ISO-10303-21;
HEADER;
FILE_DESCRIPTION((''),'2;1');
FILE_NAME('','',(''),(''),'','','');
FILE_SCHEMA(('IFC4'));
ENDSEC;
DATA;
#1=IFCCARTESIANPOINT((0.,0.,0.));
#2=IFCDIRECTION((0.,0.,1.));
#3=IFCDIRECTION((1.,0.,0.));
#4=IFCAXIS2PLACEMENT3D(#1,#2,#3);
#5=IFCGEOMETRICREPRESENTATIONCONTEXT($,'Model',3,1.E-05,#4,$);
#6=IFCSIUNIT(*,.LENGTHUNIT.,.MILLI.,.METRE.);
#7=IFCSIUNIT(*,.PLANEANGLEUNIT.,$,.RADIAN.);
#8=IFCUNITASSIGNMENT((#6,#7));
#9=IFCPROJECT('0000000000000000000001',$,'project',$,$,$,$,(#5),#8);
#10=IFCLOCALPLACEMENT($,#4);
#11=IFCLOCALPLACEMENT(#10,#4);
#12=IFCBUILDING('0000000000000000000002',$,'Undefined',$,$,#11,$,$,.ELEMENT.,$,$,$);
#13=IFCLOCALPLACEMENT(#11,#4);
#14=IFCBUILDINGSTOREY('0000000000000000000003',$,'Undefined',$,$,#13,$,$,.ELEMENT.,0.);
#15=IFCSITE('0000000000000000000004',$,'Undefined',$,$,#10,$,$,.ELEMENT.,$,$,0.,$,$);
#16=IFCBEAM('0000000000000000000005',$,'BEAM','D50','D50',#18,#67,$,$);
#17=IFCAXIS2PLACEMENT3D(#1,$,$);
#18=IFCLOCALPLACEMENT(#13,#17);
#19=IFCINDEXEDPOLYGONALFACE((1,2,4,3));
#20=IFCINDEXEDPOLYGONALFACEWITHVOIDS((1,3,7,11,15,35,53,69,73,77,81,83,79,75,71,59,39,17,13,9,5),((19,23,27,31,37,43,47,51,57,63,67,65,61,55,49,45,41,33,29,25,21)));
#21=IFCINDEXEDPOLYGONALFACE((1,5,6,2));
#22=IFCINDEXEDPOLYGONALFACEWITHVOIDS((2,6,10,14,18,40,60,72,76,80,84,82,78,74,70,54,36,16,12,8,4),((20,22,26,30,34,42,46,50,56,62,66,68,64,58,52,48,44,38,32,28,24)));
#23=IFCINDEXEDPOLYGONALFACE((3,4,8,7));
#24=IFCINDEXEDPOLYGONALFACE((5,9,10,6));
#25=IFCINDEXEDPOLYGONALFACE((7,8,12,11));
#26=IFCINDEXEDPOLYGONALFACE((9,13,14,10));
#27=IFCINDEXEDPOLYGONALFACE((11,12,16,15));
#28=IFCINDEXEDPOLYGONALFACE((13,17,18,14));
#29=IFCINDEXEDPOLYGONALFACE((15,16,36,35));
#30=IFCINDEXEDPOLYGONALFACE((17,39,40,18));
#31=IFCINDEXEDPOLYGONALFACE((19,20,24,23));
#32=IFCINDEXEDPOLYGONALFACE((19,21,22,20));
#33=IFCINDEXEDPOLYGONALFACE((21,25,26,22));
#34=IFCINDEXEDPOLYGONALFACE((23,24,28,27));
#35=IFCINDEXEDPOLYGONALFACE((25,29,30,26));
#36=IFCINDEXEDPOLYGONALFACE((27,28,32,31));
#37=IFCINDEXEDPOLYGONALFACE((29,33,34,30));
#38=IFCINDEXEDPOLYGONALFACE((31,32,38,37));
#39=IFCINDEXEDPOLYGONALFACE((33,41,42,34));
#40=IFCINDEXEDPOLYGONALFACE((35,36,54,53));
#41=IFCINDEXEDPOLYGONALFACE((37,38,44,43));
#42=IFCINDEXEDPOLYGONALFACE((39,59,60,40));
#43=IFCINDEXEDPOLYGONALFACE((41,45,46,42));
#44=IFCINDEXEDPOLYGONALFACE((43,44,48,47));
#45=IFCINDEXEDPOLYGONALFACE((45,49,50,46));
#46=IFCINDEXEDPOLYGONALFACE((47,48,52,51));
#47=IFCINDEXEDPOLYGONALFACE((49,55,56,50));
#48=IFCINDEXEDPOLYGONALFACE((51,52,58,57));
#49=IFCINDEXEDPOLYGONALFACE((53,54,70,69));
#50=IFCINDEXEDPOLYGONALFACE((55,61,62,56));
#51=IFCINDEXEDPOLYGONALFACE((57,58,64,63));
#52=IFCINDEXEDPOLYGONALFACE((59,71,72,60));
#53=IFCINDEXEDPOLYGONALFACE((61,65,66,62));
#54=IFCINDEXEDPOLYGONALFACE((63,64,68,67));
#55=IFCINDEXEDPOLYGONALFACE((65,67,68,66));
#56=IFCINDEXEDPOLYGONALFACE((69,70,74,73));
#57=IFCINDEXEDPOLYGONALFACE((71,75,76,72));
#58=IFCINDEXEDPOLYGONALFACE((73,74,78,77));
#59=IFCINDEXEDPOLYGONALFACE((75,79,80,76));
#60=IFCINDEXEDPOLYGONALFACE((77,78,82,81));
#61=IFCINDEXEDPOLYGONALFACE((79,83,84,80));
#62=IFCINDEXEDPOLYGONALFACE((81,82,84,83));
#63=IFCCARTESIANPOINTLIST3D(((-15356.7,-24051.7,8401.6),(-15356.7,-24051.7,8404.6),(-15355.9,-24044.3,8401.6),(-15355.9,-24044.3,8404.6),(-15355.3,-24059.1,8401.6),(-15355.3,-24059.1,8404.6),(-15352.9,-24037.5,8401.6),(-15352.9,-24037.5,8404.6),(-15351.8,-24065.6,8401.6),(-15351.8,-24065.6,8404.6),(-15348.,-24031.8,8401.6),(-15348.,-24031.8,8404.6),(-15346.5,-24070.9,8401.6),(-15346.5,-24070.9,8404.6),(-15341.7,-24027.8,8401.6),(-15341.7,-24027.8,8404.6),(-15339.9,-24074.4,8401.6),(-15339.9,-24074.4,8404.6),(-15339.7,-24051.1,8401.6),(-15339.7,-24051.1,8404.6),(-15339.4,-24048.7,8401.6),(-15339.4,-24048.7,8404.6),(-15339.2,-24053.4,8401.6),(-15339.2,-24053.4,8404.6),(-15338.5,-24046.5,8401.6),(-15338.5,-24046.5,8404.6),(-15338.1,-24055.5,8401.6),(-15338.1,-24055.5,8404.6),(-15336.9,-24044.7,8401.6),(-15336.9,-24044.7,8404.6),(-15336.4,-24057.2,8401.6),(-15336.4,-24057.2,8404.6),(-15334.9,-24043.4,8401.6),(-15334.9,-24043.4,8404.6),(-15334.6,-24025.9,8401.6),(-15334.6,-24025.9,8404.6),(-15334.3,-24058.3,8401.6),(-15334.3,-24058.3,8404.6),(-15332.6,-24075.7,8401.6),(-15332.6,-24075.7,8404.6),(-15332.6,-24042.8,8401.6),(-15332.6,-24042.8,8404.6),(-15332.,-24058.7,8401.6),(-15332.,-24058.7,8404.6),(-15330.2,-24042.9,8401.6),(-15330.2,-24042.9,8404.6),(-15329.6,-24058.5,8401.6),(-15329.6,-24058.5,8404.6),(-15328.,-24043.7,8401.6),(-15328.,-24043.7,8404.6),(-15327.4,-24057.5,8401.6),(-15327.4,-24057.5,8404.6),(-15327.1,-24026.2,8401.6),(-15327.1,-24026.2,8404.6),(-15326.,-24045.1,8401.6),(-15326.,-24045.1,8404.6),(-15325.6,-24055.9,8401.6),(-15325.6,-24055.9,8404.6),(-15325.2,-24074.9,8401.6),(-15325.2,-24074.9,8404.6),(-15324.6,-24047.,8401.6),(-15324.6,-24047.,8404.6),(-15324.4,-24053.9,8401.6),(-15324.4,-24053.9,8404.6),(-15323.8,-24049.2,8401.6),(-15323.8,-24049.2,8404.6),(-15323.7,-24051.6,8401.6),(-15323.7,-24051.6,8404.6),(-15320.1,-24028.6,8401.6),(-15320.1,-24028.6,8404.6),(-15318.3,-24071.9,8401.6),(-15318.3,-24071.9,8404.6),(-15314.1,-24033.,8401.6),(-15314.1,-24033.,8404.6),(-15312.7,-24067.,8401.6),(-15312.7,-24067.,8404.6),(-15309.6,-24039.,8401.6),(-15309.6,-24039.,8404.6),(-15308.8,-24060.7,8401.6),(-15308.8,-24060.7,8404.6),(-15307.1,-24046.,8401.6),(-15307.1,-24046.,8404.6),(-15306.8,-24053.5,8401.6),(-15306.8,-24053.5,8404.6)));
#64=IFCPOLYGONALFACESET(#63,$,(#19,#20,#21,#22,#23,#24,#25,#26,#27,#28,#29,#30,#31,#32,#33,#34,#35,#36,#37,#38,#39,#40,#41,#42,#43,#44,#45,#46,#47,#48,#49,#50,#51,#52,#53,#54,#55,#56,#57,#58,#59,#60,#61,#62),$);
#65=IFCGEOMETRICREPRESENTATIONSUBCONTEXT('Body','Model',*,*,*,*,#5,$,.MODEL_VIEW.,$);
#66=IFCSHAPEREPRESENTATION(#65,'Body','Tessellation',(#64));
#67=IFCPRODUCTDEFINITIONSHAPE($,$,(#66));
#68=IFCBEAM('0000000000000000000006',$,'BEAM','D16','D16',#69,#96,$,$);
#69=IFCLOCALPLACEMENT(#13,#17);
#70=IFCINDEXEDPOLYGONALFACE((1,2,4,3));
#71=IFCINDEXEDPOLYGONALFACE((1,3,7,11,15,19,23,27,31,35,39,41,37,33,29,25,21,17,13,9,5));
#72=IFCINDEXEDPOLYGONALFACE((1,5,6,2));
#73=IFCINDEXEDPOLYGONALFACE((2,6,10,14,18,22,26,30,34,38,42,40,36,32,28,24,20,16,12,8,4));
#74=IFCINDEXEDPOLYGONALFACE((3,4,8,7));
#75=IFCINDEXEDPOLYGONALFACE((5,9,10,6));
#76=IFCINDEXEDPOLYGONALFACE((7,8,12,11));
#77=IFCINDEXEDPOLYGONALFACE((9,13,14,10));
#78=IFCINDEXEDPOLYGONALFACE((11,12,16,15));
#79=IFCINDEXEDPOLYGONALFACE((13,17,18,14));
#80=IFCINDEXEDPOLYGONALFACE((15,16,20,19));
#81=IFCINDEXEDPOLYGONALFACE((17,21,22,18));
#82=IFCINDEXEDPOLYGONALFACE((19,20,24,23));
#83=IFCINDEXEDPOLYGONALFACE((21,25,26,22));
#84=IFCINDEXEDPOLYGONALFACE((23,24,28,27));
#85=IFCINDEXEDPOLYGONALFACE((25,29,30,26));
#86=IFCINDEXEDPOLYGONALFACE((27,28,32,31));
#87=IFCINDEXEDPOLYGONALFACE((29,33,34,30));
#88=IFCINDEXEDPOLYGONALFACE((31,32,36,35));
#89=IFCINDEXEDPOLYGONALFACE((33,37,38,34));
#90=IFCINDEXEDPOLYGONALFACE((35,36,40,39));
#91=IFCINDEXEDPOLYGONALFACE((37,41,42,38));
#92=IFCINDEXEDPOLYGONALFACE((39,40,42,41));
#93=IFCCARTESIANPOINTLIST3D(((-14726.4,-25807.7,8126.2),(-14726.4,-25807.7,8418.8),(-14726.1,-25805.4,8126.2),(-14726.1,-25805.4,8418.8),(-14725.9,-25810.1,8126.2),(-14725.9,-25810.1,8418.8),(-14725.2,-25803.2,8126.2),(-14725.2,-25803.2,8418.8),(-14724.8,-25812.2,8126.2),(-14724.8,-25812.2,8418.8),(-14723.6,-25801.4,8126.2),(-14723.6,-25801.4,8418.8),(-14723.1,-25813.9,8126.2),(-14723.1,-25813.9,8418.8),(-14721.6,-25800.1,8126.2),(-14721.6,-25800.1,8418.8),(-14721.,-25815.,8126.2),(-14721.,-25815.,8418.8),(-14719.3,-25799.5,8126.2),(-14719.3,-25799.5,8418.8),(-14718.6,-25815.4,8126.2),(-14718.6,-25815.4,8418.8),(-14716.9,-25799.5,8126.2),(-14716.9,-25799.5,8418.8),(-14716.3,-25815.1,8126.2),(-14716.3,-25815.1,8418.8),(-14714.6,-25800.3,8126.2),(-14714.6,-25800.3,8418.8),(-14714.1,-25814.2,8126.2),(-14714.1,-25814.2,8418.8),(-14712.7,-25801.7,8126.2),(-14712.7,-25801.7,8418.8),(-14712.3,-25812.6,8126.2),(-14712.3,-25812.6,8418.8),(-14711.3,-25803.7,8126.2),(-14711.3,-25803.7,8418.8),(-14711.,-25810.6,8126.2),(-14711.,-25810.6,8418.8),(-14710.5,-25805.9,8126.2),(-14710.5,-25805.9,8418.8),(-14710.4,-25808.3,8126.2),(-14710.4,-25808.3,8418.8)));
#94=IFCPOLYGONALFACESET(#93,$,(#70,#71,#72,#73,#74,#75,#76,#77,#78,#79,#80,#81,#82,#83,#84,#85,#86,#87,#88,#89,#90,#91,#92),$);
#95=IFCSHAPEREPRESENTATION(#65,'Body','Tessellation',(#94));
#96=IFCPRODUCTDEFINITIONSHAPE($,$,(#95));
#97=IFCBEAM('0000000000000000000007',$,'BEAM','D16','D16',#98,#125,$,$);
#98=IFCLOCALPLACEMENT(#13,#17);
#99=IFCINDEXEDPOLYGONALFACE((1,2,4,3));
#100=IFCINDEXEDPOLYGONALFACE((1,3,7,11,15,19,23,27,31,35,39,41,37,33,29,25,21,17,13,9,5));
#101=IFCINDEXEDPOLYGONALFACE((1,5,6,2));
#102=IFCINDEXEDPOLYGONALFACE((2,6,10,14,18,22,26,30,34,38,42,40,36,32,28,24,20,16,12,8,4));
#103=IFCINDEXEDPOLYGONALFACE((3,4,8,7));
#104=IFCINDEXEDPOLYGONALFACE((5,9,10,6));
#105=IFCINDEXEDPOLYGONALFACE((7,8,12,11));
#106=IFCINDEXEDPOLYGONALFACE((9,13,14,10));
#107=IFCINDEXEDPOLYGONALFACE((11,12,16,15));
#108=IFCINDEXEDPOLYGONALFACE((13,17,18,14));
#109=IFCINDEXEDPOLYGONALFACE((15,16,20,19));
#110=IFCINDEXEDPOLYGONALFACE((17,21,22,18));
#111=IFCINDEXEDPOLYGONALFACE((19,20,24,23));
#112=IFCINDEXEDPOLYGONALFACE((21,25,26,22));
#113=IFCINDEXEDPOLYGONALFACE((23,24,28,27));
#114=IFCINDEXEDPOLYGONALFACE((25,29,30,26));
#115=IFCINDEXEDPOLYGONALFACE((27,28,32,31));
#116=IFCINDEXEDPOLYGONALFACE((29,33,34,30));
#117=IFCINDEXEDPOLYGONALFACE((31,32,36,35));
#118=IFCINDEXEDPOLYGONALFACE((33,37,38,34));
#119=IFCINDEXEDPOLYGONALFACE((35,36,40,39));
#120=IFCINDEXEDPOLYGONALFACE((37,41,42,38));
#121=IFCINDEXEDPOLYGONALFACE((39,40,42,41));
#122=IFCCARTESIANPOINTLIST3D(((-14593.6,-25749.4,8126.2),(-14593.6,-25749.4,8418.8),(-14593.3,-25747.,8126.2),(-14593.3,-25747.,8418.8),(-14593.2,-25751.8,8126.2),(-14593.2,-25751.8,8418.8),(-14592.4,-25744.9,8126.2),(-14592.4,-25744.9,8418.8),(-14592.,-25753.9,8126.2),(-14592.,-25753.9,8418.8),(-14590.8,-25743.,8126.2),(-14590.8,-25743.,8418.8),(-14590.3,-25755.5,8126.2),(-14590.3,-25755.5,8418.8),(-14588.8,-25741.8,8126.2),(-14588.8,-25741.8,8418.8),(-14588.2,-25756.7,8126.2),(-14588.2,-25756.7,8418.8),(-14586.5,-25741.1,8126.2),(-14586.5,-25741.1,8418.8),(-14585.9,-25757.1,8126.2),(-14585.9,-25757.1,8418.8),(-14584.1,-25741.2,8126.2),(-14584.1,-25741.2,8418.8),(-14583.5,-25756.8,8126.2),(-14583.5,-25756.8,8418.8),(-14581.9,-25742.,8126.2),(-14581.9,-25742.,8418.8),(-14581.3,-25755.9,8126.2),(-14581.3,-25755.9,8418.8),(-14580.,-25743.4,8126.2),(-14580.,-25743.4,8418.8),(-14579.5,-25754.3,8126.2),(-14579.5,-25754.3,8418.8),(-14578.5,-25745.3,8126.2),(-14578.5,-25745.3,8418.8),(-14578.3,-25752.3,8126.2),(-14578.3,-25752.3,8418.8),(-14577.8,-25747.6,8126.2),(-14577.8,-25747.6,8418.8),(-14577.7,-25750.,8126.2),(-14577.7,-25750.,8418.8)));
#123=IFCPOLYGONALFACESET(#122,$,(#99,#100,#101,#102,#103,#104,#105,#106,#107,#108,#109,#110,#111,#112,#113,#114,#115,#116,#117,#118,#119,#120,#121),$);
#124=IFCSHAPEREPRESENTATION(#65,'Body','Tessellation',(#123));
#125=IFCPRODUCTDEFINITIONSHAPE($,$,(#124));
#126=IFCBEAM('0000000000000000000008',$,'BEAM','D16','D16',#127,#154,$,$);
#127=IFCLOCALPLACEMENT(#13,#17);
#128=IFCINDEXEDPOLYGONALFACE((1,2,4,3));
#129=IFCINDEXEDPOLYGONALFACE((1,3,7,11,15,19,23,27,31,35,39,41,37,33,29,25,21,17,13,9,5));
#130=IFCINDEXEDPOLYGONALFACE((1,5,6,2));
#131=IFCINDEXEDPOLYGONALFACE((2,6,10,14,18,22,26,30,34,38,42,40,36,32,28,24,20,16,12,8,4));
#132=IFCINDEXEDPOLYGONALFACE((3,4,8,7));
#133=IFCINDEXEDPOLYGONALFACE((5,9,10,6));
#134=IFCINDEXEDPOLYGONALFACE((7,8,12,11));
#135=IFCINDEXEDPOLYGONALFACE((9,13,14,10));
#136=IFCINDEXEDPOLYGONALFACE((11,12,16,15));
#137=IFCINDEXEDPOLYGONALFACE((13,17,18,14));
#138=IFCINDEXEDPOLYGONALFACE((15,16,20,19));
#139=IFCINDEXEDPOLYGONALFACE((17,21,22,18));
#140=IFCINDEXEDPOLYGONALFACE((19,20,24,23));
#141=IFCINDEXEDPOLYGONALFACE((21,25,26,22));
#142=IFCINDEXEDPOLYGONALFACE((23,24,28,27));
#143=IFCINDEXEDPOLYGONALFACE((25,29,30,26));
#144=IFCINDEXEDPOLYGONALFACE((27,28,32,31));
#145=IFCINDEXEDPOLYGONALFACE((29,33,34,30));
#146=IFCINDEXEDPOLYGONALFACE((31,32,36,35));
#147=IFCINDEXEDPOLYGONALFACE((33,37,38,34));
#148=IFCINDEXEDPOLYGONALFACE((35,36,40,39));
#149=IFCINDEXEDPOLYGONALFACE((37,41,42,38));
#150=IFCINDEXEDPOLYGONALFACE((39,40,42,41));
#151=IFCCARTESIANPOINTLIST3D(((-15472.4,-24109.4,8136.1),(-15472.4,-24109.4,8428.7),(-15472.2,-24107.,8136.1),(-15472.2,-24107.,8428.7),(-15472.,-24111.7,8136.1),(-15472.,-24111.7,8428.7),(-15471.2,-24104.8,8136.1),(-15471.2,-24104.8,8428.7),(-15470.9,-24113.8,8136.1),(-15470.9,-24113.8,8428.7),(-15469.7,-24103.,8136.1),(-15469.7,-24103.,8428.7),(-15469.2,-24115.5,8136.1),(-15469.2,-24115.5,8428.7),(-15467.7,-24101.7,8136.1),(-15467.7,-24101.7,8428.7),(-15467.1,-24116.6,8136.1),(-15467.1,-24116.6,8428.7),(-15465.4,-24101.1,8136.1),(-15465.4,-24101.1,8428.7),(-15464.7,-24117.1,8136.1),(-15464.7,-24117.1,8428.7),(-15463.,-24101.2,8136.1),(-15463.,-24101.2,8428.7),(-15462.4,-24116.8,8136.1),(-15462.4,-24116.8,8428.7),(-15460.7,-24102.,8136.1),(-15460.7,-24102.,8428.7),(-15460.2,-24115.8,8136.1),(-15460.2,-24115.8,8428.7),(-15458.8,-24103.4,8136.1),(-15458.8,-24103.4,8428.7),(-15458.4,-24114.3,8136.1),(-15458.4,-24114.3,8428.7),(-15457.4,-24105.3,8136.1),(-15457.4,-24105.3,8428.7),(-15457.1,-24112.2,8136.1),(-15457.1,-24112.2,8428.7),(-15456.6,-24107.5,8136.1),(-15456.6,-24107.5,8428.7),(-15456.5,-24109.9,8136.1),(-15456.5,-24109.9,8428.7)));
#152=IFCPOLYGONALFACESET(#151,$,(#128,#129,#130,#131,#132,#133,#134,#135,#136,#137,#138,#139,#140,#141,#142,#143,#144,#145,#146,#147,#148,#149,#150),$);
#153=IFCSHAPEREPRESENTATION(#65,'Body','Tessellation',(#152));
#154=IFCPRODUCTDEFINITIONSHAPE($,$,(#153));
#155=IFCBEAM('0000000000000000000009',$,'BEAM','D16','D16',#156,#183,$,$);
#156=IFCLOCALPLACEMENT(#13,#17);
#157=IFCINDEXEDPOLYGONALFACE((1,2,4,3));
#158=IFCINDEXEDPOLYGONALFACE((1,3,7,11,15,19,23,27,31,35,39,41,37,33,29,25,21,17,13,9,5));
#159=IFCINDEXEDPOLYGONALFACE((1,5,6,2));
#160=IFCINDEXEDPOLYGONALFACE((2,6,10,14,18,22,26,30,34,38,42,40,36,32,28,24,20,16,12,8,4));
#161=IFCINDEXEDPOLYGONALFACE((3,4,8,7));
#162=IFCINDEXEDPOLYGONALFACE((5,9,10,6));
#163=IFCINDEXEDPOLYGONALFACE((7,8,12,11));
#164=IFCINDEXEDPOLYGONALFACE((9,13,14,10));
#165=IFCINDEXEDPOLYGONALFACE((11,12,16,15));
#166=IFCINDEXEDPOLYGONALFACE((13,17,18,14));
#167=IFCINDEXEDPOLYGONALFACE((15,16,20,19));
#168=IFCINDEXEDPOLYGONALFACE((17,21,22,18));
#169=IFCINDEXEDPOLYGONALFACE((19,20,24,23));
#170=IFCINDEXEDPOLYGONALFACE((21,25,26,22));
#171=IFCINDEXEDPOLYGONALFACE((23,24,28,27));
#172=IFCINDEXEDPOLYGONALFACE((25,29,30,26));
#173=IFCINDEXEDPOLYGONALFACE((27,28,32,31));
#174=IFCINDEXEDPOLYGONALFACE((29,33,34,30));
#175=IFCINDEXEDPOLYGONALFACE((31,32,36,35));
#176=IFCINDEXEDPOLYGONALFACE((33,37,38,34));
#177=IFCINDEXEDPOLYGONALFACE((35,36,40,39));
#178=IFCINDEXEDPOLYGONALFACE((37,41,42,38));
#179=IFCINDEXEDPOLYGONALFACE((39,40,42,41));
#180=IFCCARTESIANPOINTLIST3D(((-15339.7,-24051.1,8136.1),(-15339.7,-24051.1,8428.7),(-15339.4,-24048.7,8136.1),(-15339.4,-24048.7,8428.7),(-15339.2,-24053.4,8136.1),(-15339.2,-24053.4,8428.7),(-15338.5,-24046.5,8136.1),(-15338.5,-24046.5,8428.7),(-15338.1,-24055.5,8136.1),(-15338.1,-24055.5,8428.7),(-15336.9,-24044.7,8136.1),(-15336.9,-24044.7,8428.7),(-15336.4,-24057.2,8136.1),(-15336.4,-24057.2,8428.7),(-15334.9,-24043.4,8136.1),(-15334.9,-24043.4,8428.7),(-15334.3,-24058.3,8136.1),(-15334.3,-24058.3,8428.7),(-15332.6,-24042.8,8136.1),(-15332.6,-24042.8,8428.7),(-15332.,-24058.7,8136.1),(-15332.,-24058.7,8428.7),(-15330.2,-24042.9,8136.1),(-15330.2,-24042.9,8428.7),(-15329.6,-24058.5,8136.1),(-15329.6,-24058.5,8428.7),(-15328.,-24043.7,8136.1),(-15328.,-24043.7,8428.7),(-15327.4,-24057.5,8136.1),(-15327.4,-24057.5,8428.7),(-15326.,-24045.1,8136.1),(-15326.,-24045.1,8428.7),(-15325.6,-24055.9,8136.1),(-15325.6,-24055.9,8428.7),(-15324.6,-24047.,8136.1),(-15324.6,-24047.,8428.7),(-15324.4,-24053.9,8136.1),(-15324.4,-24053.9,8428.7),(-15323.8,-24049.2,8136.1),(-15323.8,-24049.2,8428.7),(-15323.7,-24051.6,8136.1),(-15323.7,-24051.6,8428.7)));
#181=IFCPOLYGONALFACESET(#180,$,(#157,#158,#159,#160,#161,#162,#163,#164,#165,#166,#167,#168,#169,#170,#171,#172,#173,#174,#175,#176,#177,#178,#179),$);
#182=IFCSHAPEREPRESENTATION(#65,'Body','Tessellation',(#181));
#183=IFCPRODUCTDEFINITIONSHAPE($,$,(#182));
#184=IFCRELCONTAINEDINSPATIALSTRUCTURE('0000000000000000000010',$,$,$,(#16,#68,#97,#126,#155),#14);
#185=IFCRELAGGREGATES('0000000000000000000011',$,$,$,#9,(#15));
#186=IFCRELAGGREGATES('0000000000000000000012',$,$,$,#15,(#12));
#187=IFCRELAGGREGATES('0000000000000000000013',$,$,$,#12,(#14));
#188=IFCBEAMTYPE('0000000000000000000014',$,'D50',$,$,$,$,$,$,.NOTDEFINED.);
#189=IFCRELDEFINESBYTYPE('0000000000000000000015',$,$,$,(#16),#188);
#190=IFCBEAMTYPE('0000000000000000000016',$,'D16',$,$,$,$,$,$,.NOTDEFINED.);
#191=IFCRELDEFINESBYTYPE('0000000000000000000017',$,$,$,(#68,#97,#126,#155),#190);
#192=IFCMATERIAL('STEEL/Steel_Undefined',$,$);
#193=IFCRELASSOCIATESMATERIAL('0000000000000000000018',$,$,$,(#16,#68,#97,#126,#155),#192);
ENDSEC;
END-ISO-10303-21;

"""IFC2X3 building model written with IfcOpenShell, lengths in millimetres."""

from ifc_helpers import new_model, si_unit, frame, origin_with_axes, origin_2d_with_axis, place, context, subcontext, project, spatial, circle, extrude, material, type_object, element, save


model = new_model("IFC2X3")

# Units and contexts
model_context = context("Model", 3, precision=1e-05, world=origin_with_axes())
body_context = subcontext(model_context, "Body", "Model", "MODEL_VIEW")
ifc_project = project(units=[si_unit("LENGTHUNIT", "METRE", prefix="MILLI"), si_unit("PLANEANGLEUNIT", "RADIAN")], contexts=[model_context])

# Site, building, storey
site_placement = place(None, origin_with_axes())
site = spatial("IfcSite", under=ifc_project, at=site_placement, Name="Undefined", CompositionType="ELEMENT", RefElevation=0.0)
building_placement = place(site_placement, origin_with_axes())
building = spatial("IfcBuilding", under=site, at=building_placement, Name="Undefined", CompositionType="ELEMENT")
storey_placement = place(building_placement, origin_with_axes())
storey = spatial("IfcBuildingStorey", under=building, at=storey_placement, Name="Undefined", CompositionType="ELEMENT", Elevation=0.0)

# Beam, opening
ifc_material = material(Name="STEEL/Steel_Undefined")
beam_type_1 = type_object("IfcBeamType", Name="D50", PredefinedType="NOTDEFINED")
beam_1_placement = place(storey_placement, frame((-15331.7, -24050.7, 8404.6), z_axis=(-0.915552, -0.4022, 0.0), x_axis=(0.0, 0.0, -1.0)))
beam_1 = element("IfcBeam", 1, at=beam_1_placement, inside=storey, type_object=beam_type_1, material=ifc_material, Name="BEAM", Description="D50", ObjectType="D50", context=body_context, shape_type="SweptSolid", body=[
    extrude(circle(Radius=25.0, at=origin_2d_with_axis()), frame((3.0, 0.0, 0.0), z_axis=(-1.0, 0.0, 0.0), x_axis=(0.0, -1.0, 0.0)), (0.0, 0.0, 1.0), 3.0),
])
opening_1_placement = place(storey_placement, frame((-15331.7, -24050.7, 8404.6), z_axis=(-0.915552, -0.4022, 0.0), x_axis=(0.0, 0.0, -1.0)))
element("IfcOpeningElement", 2, at=opening_1_placement, cuts=beam_1, ObjectType="Recess", context=body_context, shape_type="SweptSolid", body=[
    extrude(circle(Radius=8.0, at=origin_2d_with_axis()), frame((268.5, 0.0, 0.0), z_axis=(-1.0, 0.0, 0.0), x_axis=(0.0, -1.0, 0.0)), (0.0, 0.0, 1.0), 292.6),
])

# Beams
beam_type_2 = type_object("IfcBeamType", Name="D16", PredefinedType="NOTDEFINED")
for number, where, z_axis, x_axis, name in (
    (3, (-14718.4, -25807.4, 8418.8), (-0.915553, -0.402197, 0.0), (0.0, 0.0, -1.0), "BEAM"),
    (4, (-14585.6, -25749.1, 8418.8), (-0.915553, -0.402197, 0.0), (0.0, 0.0, -1.0), "BEAM"),
    (5, (-15464.4, -24109.1, 8428.7), (-0.915552, -0.4022, 0.0), (0.0, 0.0, -1.0), "BEAM"),
    (6, (-15331.7, -24050.7, 8428.7), (-0.915552, -0.4022, 0.0), (0.0, 0.0, -1.0), "BEAM"),
):
    element("IfcBeam", number, at=place(storey_placement, frame(where, z_axis=z_axis, x_axis=x_axis)), inside=storey, type_object=beam_type_2, material=ifc_material, Name=name, Description="D16", ObjectType="D16", context=body_context, shape_type="SweptSolid", body=[
        extrude(circle(Radius=8.0, at=origin_2d_with_axis()), frame((292.6, 0.0, 0.0), z_axis=(-1.0, 0.0, 0.0), x_axis=(0.0, -1.0, 0.0)), (0.0, 0.0, 1.0), 292.6),
    ])

save(model, "model.ifc")
